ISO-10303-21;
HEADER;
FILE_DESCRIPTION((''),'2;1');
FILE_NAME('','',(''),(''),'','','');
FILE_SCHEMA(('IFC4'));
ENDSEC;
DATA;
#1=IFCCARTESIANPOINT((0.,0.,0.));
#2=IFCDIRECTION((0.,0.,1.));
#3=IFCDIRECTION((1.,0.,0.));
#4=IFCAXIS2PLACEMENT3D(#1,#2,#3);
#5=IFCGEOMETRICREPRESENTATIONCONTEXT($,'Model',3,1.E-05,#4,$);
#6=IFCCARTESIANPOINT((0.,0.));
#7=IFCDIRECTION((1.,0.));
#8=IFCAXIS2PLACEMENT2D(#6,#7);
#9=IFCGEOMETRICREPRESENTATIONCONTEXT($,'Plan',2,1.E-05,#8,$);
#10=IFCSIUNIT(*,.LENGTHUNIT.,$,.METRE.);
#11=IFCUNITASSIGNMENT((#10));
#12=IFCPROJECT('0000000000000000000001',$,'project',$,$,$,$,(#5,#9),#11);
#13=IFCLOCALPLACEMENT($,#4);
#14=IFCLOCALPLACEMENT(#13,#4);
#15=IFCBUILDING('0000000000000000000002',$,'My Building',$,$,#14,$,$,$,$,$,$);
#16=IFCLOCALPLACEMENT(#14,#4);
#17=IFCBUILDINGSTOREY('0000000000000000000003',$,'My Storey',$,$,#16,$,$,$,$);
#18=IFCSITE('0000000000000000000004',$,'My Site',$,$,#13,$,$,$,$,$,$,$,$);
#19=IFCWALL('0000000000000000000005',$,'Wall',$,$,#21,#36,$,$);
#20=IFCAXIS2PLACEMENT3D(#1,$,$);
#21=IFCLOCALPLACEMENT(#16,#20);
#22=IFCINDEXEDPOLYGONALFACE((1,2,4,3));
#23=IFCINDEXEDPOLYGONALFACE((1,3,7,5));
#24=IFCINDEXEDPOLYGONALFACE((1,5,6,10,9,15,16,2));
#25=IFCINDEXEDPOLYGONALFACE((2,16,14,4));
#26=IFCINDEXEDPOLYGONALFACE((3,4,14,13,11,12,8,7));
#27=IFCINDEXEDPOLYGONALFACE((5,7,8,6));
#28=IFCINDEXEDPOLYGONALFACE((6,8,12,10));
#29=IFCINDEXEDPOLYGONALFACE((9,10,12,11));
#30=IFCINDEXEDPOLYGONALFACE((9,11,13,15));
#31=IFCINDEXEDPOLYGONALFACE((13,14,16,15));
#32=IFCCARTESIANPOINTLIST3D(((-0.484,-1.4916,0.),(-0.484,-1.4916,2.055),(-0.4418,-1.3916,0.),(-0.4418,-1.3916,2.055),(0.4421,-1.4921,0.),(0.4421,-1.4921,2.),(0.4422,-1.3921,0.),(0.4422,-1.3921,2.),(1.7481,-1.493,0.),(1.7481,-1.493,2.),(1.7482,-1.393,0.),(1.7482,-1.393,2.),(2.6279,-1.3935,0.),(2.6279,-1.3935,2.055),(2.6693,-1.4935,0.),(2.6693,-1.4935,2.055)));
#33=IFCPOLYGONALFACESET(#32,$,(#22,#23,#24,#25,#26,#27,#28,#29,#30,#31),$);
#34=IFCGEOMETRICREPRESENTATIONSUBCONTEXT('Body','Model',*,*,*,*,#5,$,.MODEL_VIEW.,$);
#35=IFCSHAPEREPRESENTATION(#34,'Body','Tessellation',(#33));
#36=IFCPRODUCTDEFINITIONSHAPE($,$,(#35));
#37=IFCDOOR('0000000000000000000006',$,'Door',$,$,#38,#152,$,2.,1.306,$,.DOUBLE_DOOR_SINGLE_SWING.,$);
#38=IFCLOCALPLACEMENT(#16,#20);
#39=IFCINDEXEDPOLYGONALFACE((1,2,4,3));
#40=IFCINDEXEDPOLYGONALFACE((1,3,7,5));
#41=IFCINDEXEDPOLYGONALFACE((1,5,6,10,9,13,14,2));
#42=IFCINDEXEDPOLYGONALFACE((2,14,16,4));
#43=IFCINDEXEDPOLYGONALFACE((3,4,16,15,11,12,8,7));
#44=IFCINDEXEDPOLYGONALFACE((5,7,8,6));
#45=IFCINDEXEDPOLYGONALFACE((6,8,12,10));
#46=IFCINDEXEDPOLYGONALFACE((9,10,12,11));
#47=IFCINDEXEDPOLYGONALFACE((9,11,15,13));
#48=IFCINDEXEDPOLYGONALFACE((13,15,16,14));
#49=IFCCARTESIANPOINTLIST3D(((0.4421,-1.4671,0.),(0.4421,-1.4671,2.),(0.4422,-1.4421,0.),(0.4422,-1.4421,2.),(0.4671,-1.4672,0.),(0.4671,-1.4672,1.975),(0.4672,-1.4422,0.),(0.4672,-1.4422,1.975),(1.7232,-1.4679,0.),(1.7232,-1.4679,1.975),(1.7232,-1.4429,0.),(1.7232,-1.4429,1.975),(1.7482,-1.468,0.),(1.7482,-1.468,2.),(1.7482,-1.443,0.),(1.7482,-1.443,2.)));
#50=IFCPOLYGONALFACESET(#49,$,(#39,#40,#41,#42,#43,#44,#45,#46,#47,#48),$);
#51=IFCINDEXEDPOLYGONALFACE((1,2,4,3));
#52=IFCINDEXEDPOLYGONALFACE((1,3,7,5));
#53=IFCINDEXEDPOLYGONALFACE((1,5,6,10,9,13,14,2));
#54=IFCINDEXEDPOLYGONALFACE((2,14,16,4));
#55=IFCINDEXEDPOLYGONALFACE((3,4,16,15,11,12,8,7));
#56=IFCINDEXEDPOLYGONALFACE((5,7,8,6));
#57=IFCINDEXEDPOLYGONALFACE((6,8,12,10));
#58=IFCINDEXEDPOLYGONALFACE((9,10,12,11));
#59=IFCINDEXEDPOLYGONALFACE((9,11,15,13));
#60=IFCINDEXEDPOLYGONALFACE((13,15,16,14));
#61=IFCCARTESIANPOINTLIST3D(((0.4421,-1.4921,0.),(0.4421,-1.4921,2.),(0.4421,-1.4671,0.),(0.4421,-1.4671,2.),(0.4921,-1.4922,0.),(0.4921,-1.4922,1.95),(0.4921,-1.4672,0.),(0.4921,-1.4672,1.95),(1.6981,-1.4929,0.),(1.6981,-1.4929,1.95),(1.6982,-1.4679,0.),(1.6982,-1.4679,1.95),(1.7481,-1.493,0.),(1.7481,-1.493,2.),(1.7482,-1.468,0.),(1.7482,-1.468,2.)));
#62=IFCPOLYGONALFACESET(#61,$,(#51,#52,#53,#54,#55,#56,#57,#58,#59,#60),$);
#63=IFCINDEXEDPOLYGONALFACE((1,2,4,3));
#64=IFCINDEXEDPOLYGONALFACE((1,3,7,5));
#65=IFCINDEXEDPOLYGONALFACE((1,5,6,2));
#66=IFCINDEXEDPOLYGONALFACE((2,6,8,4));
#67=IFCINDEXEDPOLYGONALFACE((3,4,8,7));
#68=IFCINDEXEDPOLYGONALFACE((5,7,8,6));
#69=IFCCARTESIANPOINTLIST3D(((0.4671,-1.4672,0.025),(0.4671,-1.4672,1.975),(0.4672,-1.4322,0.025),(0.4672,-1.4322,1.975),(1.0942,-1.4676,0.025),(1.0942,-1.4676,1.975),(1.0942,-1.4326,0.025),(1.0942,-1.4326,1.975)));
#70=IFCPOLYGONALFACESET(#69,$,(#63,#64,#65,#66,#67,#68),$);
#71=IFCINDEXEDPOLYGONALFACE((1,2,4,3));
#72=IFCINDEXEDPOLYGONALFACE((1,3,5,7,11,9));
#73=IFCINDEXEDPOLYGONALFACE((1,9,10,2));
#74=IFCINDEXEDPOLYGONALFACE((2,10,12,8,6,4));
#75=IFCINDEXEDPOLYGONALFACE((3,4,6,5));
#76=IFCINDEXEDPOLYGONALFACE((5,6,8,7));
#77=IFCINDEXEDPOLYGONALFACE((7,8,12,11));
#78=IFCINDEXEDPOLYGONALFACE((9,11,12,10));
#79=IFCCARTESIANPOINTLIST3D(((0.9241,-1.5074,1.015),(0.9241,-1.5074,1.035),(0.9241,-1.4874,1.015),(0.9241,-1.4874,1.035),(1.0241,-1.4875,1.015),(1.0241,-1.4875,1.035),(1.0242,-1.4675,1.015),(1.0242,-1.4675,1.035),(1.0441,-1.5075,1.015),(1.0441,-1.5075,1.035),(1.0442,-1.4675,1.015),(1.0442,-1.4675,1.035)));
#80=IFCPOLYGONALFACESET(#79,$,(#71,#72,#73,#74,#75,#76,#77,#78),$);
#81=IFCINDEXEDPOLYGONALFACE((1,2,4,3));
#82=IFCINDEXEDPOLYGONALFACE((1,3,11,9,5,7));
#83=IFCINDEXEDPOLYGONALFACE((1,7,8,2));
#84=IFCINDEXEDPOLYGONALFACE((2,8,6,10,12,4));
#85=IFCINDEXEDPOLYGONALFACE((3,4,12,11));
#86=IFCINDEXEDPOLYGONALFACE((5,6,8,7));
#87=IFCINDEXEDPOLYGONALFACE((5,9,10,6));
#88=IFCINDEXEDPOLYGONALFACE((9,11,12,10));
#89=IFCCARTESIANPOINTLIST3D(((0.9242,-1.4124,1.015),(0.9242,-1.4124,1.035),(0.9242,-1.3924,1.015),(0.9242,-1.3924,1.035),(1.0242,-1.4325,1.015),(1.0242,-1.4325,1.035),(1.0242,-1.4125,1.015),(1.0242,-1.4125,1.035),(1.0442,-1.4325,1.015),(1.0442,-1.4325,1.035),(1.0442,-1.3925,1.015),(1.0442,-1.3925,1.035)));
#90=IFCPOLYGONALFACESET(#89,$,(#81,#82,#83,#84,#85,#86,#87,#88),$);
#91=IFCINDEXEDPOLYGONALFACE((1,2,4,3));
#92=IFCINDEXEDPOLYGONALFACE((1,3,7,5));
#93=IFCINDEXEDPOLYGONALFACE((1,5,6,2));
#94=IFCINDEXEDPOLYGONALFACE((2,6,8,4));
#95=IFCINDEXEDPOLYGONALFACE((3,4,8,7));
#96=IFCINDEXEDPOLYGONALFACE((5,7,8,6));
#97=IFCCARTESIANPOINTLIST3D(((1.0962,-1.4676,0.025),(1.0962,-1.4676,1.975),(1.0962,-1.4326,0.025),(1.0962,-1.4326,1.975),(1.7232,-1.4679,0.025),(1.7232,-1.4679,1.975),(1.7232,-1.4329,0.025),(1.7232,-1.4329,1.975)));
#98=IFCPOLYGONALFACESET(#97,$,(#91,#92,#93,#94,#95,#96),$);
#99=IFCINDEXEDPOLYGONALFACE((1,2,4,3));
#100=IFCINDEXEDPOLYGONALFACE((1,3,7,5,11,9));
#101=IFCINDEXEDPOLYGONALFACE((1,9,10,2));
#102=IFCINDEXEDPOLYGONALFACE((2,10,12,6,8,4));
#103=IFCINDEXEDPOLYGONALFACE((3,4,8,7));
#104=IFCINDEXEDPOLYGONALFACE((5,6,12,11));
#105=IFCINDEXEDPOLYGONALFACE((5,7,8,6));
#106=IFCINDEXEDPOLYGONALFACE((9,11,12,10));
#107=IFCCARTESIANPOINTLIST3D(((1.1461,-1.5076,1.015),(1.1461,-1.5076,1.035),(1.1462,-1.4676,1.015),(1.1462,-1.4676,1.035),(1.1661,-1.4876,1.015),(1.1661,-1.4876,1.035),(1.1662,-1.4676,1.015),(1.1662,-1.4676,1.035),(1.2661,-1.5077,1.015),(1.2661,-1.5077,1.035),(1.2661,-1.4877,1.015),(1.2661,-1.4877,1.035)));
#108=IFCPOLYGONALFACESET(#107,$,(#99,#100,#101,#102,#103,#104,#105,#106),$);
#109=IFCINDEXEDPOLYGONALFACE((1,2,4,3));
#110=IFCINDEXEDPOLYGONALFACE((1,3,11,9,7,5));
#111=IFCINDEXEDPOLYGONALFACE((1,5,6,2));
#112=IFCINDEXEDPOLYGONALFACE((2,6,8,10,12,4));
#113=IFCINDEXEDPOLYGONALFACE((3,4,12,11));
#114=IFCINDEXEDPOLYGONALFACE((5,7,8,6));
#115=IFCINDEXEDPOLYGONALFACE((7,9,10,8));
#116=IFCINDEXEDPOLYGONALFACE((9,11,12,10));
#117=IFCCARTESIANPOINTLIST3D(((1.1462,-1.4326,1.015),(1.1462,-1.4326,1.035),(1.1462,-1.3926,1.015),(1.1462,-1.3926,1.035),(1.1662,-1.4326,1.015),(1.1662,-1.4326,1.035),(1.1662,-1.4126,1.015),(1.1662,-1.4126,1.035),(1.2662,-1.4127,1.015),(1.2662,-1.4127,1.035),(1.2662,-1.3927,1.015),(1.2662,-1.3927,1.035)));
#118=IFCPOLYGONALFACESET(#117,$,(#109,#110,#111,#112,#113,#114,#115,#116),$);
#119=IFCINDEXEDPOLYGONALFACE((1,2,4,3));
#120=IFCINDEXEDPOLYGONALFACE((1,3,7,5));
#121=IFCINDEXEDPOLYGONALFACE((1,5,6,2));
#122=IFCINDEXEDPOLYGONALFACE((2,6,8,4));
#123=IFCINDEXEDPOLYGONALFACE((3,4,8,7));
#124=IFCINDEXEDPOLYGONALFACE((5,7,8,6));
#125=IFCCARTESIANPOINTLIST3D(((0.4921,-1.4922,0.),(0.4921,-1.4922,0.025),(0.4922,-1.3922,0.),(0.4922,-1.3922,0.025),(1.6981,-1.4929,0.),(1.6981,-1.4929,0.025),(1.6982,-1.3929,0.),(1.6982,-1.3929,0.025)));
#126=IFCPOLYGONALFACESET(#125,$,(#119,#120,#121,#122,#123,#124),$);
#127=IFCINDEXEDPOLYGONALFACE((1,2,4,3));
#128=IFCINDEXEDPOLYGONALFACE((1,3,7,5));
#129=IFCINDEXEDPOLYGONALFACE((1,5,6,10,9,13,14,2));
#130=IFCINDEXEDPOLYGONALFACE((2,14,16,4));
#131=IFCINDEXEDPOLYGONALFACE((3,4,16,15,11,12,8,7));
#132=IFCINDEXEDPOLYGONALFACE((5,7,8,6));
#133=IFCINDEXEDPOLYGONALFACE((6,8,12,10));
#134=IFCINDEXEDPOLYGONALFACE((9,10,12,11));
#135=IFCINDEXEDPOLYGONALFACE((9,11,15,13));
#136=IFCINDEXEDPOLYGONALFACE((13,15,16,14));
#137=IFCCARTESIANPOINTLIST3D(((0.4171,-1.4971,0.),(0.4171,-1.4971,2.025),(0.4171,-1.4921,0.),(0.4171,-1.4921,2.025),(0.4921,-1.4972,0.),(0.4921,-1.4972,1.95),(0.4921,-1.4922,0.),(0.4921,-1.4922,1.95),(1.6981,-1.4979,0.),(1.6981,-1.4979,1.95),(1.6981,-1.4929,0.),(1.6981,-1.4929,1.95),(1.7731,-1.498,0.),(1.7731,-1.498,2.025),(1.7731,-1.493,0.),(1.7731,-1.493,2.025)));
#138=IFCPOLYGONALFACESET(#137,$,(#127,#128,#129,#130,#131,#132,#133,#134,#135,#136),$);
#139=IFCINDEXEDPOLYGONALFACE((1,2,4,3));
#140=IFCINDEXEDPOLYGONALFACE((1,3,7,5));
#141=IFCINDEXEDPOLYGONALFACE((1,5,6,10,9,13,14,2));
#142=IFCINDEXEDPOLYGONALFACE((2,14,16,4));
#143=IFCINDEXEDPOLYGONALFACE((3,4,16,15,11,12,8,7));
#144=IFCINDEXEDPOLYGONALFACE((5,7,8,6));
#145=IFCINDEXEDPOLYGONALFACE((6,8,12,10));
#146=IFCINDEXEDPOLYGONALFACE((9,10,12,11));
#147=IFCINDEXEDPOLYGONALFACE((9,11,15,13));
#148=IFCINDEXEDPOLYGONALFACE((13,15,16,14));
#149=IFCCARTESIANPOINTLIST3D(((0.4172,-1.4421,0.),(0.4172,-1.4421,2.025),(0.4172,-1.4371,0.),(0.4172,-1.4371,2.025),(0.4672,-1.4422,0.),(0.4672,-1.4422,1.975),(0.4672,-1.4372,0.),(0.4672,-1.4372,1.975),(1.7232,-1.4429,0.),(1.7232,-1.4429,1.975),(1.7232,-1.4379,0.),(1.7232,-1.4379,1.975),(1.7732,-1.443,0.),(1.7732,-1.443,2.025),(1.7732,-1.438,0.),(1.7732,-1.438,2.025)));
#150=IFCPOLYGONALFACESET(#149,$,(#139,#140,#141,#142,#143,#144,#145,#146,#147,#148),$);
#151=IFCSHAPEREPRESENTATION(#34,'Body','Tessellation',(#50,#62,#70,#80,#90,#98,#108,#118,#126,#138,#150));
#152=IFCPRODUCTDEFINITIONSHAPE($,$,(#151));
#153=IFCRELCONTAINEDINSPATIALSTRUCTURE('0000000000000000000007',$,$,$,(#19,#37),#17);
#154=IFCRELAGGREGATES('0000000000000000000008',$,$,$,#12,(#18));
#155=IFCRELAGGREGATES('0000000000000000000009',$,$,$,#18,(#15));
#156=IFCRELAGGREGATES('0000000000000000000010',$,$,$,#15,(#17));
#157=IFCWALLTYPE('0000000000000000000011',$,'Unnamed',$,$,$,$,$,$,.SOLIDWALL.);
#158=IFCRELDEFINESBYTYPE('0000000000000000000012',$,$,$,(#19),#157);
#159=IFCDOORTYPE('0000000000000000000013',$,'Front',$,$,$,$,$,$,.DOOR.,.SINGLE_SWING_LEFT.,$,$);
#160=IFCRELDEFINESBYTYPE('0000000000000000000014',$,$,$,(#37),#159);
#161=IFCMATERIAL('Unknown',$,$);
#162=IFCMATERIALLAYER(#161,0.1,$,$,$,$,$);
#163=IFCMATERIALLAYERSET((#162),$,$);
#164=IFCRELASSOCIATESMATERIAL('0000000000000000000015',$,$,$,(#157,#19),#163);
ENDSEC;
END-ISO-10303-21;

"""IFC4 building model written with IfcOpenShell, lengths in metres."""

from ifc_helpers import new_model, entity, si_unit, frame, origin_with_axes, origin_2d_with_axis, place, context, subcontext, project, spatial, line, indexed_curve, outline, extrude, shape, source, transform, mapped, material, layer, layer_set, layer_usage, type_object, type_shapes, element, fill, save


model = new_model("IFC4")

# Units and contexts
model_context = context("Model", 3, precision=1e-05, world=origin_with_axes())
plan_context = context("Plan", 2, precision=1e-05, world=origin_2d_with_axis())
body_context_1 = subcontext(model_context, "Body", "Model", "MODEL_VIEW")
body_context_2 = subcontext(plan_context, "Body", "Plan", "PLAN_VIEW")
ifc_project = project(units=[si_unit("LENGTHUNIT", "METRE")], contexts=[model_context, plan_context])

# Site, building, storey
site_placement = place(None, origin_with_axes())
site = spatial("IfcSite", under=ifc_project, at=site_placement, Name="My Site")
building_placement = place(site_placement, origin_with_axes())
building = spatial("IfcBuilding", under=site, at=building_placement, Name="My Building")
storey_placement = place(building_placement, origin_with_axes())
storey = spatial("IfcBuildingStorey", under=building, at=storey_placement, Name="My Storey")

# Shared definitions
ifc_material = material(Name="Unknown")

# Wall, opening, door
ifc_layer_1 = layer(ifc_material, 0.1)
ifc_layer_set_1 = layer_set([ifc_layer_1])
ifc_layer_usage_1 = layer_usage(ifc_layer_set_1, "AXIS2", "POSITIVE", 0.0)
wall_type = type_object("IfcWallType", Name="Unnamed", PredefinedType="SOLIDWALL", material=ifc_layer_set_1)
wall_1_placement = place(storey_placement, frame((-0.484, -1.4916, 0.0), z_axis=(0.0, 0.0, 1.0), x_axis=(1.0, -0.000615, 0.0)))
wall_1 = element("IfcWall", 1, at=wall_1_placement, inside=storey, type_object=wall_type, material=ifc_layer_usage_1, Name="Wall", context=body_context_1, shape_type="SweptSolid", body=[
    extrude(outline(indexed_curve([(0.0, 0.0), (0.0422, 0.1), (3.1119, 0.1), (3.1533, 0.0)], segments=[line(1, 2, 3, 4, 1)])), origin_with_axes(), (0.0, 0.0, 1.0), 2.055),
])
shared_shape_1 = source(origin_with_axes(), body_context_1, "Body", "SweptSolid", [
    extrude(outline(indexed_curve([(0.0, 0.0), (1.306, 0.0), (1.306, 2.0), (0.0, 2.0)], segments=[line(1, 2, 3, 4, 1)])), frame((0.0, -0.6, 0.0), z_axis=(0.0, -1.0, 0.0), x_axis=(1.0, 0.0, 0.0)), (0.0, 0.0, -1.0), 1.2),
])
opening_1_placement = place(wall_1_placement, frame((0.9261, 0.0, 0.0), z_axis=(0.0, 0.0, 1.0), x_axis=(1.0, 0.0, 0.0)))
opening_1 = element("IfcOpeningElement", 2, at=opening_1_placement, cuts=wall_1, PredefinedType="OPENING", context=body_context_1, shape_type="MappedRepresentation", body=[
    mapped(shared_shape_1, transform((0.0, 0.0, 0.0), x_axis=(1.0, 0.0, 0.0), y_axis=(0.0, 1.0, 0.0), z_axis=(0.0, 0.0, 1.0), scale=1.0)),
])
door_type_1 = type_object("IfcDoorType", Name="Front", OperationType="SINGLE_SWING_LEFT", PredefinedType="DOOR")
shared_shape_2 = source(origin_with_axes(), body_context_1, "Body", "SweptSolid", [
    extrude(outline(indexed_curve([(0.0, 0.0), (0.0, 2.0), (1.306, 2.0), (1.306, 0.0), (1.281, 0.0), (1.281, 1.975), (0.025, 1.975), (0.025, 0.0)], segments=[line(1, 2, 3, 4, 5, 6, 7, 8, 1)])), frame((0.0, 0.025, 0.0), z_axis=(0.0, -1.0, 0.0), x_axis=(1.0, 0.0, 0.0)), (0.0, 0.0, -1.0), 0.025),
    extrude(outline(indexed_curve([(0.0, 0.0), (0.0, 2.0), (1.306, 2.0), (1.306, 0.0), (1.256, 0.0), (1.256, 1.95), (0.05, 1.95), (0.05, 0.0)], segments=[line(1, 2, 3, 4, 5, 6, 7, 8, 1)])), frame((0.0, 0.0, 0.0), z_axis=(0.0, -1.0, 0.0), x_axis=(1.0, 0.0, 0.0)), (0.0, 0.0, -1.0), 0.025),
    extrude(outline(indexed_curve([(0.0, 0.0), (0.627, 0.0), (0.627, 0.035), (0.0, 0.035)], segments=[line(1, 2, 3, 4, 1)])), frame((0.025, 0.025, 0.025), z_axis=(0.0, 0.0, 1.0), x_axis=(1.0, 0.0, 0.0)), (0.0, 0.0, 1.0), 1.95),
    extrude(outline(indexed_curve([(-0.02, 0.0), (-0.02, -0.02), (-0.12, -0.02), (-0.12, -0.04), (0.0, -0.04), (0.0, 0.0), (-0.02, 0.0)])), frame((0.602, 0.025, 1.015), z_axis=(0.0, 0.0, 1.0), x_axis=(1.0, 0.0, 0.0)), (0.0, 0.0, 1.0), 0.02),
    extrude(outline(indexed_curve([(0.0, 0.0), (0.0, 0.04), (-0.12, 0.04), (-0.12, 0.02), (-0.02, 0.02), (-0.02, 0.0)], segments=[line(1, 2, 3, 4, 5, 6, 1)])), frame((0.602, 0.06, 1.015), z_axis=(0.0, 0.0, 1.0), x_axis=(1.0, 0.0, 0.0)), (0.0, 0.0, 1.0), 0.02),
    extrude(outline(indexed_curve([(0.0, 0.0), (-0.627, 0.0), (-0.627, 0.035), (0.0, 0.035)], segments=[line(1, 2, 3, 4, 1)])), frame((1.281, 0.025, 0.025), z_axis=(0.0, 0.0, 1.0), x_axis=(1.0, 0.0, 0.0)), (0.0, 0.0, 1.0), 1.95),
    extrude(outline(indexed_curve([(0.0, 0.0), (0.0, -0.04), (0.12, -0.04), (0.12, -0.02), (0.02, -0.02), (0.02, 0.0)], segments=[line(1, 2, 3, 4, 5, 6, 1)])), frame((0.704, 0.025, 1.015), z_axis=(0.0, 0.0, 1.0), x_axis=(1.0, 0.0, 0.0)), (0.0, 0.0, 1.0), 0.02),
    extrude(outline(indexed_curve([(0.0, 0.0), (0.0, 0.04), (0.12, 0.04), (0.12, 0.02), (0.02, 0.02), (0.02, 0.0)], segments=[line(1, 2, 3, 4, 5, 6, 1)])), frame((0.704, 0.06, 1.015), z_axis=(0.0, 0.0, 1.0), x_axis=(1.0, 0.0, 0.0)), (0.0, 0.0, 1.0), 0.02),
    extrude(outline(indexed_curve([(0.0, 0.0), (1.206, 0.0), (1.206, 0.1), (0.0, 0.1)], segments=[line(1, 2, 3, 4, 1)])), frame((0.05, 0.0, 0.0), z_axis=(0.0, 0.0, 1.0), x_axis=(1.0, 0.0, 0.0)), (0.0, 0.0, 1.0), 0.025),
    extrude(outline(indexed_curve([(0.0, 0.0), (0.0, 2.025), (1.356, 2.025), (1.356, 0.0), (1.281, 0.0), (1.281, 1.95), (0.075, 1.95), (0.075, 0.0)], segments=[line(1, 2, 3, 4, 5, 6, 7, 8, 1)])), frame((-0.025, -0.005, 0.0), z_axis=(0.0, -1.0, 0.0), x_axis=(1.0, 0.0, 0.0)), (0.0, 0.0, -1.0), 0.005),
    extrude(outline(indexed_curve([(0.0, 0.0), (0.0, 2.025), (1.356, 2.025), (1.356, 0.0), (1.306, 0.0), (1.306, 1.975), (0.05, 1.975), (0.05, 0.0)], segments=[line(1, 2, 3, 4, 5, 6, 7, 8, 1)])), frame((-0.025, 0.05, 0.0), z_axis=(0.0, -1.0, 0.0), x_axis=(1.0, 0.0, 0.0)), (0.0, 0.0, -1.0), 0.005),
])
shared_shape_3 = source(origin_with_axes(), body_context_2, "Body", "Curve2D", [
    entity("IfcIndexedPolyCurve", entity("IfcCartesianPointList2D", [[0.0, 0.0], [0.0, 0.05], [0.025, 0.05], [0.025, 0.025], [0.05, 0.025], [0.05, 0.0]]), [entity("IfcLineIndex", [1, 2, 3, 4, 5, 6, 1])]),
    entity("IfcIndexedPolyCurve", entity("IfcCartesianPointList2D", [[1.306, 0.0], [1.306, 0.05], [1.281, 0.05], [1.281, 0.025], [1.256, 0.025], [1.256, 0.0]]), [entity("IfcLineIndex", [1, 2, 3, 4, 5, 6, 1])]),
    entity("IfcTrimmedCurve", entity("IfcEllipse", entity("IfcAxis2Placement2D", entity("IfcCartesianPoint", [0.06, 0.05]), entity("IfcDirection", [1.0, 0.0])), 0.593, 0.628), [entity("IfcCartesianPoint", [0.653, 0.05])], [entity("IfcCartesianPoint", [0.06, 0.678])], True, "CARTESIAN"),
    entity("IfcIndexedPolyCurve", entity("IfcCartesianPointList2D", [[0.025, 0.05], [0.06, 0.05], [0.06, 0.678], [0.025, 0.678]]), [entity("IfcLineIndex", [1, 2, 3, 4, 1])]),
    entity("IfcTrimmedCurve", entity("IfcEllipse", entity("IfcAxis2Placement2D", entity("IfcCartesianPoint", [1.246, 0.05]), entity("IfcDirection", [1.0, 0.0])), 0.593, 0.628), [entity("IfcCartesianPoint", [1.246, 0.678])], [entity("IfcCartesianPoint", [0.653, 0.05])], True, "CARTESIAN"),
    entity("IfcIndexedPolyCurve", entity("IfcCartesianPointList2D", [[1.281, 0.05], [1.246, 0.05], [1.246, 0.678], [1.281, 0.678]]), [entity("IfcLineIndex", [1, 2, 3, 4, 1])]),
])
type_shapes(door_type_1, [shared_shape_2, shared_shape_3])
door_1_placement = place(opening_1_placement, frame((0.0, 0.0, 0.0), z_axis=(0.0, 0.0, 1.0), x_axis=(1.0, 0.0, 0.0)))
door_1 = element("IfcDoor", 3, at=door_1_placement, inside=storey, type_object=door_type_1, Name="Door", OperationType="DOUBLE_DOOR_SINGLE_SWING", OverallHeight=2.0, OverallWidth=1.306, shapes=[
    shape(body_context_1, "Body", "MappedRepresentation", [mapped(shared_shape_2, transform((0.0, 0.0, 0.0), x_axis=(1.0, 0.0, 0.0), y_axis=(0.0, 1.0, 0.0), z_axis=(0.0, 0.0, 1.0), scale=1.0))]),
    shape(body_context_2, "Body", "MappedRepresentation", [mapped(shared_shape_3, transform((0.0, 0.0, 0.0), x_axis=(1.0, 0.0, 0.0), y_axis=(0.0, 1.0, 0.0), z_axis=(0.0, 0.0, 1.0), scale=1.0))]),
])
fill(opening_1, door_1)

save(model, "model.ifc")
